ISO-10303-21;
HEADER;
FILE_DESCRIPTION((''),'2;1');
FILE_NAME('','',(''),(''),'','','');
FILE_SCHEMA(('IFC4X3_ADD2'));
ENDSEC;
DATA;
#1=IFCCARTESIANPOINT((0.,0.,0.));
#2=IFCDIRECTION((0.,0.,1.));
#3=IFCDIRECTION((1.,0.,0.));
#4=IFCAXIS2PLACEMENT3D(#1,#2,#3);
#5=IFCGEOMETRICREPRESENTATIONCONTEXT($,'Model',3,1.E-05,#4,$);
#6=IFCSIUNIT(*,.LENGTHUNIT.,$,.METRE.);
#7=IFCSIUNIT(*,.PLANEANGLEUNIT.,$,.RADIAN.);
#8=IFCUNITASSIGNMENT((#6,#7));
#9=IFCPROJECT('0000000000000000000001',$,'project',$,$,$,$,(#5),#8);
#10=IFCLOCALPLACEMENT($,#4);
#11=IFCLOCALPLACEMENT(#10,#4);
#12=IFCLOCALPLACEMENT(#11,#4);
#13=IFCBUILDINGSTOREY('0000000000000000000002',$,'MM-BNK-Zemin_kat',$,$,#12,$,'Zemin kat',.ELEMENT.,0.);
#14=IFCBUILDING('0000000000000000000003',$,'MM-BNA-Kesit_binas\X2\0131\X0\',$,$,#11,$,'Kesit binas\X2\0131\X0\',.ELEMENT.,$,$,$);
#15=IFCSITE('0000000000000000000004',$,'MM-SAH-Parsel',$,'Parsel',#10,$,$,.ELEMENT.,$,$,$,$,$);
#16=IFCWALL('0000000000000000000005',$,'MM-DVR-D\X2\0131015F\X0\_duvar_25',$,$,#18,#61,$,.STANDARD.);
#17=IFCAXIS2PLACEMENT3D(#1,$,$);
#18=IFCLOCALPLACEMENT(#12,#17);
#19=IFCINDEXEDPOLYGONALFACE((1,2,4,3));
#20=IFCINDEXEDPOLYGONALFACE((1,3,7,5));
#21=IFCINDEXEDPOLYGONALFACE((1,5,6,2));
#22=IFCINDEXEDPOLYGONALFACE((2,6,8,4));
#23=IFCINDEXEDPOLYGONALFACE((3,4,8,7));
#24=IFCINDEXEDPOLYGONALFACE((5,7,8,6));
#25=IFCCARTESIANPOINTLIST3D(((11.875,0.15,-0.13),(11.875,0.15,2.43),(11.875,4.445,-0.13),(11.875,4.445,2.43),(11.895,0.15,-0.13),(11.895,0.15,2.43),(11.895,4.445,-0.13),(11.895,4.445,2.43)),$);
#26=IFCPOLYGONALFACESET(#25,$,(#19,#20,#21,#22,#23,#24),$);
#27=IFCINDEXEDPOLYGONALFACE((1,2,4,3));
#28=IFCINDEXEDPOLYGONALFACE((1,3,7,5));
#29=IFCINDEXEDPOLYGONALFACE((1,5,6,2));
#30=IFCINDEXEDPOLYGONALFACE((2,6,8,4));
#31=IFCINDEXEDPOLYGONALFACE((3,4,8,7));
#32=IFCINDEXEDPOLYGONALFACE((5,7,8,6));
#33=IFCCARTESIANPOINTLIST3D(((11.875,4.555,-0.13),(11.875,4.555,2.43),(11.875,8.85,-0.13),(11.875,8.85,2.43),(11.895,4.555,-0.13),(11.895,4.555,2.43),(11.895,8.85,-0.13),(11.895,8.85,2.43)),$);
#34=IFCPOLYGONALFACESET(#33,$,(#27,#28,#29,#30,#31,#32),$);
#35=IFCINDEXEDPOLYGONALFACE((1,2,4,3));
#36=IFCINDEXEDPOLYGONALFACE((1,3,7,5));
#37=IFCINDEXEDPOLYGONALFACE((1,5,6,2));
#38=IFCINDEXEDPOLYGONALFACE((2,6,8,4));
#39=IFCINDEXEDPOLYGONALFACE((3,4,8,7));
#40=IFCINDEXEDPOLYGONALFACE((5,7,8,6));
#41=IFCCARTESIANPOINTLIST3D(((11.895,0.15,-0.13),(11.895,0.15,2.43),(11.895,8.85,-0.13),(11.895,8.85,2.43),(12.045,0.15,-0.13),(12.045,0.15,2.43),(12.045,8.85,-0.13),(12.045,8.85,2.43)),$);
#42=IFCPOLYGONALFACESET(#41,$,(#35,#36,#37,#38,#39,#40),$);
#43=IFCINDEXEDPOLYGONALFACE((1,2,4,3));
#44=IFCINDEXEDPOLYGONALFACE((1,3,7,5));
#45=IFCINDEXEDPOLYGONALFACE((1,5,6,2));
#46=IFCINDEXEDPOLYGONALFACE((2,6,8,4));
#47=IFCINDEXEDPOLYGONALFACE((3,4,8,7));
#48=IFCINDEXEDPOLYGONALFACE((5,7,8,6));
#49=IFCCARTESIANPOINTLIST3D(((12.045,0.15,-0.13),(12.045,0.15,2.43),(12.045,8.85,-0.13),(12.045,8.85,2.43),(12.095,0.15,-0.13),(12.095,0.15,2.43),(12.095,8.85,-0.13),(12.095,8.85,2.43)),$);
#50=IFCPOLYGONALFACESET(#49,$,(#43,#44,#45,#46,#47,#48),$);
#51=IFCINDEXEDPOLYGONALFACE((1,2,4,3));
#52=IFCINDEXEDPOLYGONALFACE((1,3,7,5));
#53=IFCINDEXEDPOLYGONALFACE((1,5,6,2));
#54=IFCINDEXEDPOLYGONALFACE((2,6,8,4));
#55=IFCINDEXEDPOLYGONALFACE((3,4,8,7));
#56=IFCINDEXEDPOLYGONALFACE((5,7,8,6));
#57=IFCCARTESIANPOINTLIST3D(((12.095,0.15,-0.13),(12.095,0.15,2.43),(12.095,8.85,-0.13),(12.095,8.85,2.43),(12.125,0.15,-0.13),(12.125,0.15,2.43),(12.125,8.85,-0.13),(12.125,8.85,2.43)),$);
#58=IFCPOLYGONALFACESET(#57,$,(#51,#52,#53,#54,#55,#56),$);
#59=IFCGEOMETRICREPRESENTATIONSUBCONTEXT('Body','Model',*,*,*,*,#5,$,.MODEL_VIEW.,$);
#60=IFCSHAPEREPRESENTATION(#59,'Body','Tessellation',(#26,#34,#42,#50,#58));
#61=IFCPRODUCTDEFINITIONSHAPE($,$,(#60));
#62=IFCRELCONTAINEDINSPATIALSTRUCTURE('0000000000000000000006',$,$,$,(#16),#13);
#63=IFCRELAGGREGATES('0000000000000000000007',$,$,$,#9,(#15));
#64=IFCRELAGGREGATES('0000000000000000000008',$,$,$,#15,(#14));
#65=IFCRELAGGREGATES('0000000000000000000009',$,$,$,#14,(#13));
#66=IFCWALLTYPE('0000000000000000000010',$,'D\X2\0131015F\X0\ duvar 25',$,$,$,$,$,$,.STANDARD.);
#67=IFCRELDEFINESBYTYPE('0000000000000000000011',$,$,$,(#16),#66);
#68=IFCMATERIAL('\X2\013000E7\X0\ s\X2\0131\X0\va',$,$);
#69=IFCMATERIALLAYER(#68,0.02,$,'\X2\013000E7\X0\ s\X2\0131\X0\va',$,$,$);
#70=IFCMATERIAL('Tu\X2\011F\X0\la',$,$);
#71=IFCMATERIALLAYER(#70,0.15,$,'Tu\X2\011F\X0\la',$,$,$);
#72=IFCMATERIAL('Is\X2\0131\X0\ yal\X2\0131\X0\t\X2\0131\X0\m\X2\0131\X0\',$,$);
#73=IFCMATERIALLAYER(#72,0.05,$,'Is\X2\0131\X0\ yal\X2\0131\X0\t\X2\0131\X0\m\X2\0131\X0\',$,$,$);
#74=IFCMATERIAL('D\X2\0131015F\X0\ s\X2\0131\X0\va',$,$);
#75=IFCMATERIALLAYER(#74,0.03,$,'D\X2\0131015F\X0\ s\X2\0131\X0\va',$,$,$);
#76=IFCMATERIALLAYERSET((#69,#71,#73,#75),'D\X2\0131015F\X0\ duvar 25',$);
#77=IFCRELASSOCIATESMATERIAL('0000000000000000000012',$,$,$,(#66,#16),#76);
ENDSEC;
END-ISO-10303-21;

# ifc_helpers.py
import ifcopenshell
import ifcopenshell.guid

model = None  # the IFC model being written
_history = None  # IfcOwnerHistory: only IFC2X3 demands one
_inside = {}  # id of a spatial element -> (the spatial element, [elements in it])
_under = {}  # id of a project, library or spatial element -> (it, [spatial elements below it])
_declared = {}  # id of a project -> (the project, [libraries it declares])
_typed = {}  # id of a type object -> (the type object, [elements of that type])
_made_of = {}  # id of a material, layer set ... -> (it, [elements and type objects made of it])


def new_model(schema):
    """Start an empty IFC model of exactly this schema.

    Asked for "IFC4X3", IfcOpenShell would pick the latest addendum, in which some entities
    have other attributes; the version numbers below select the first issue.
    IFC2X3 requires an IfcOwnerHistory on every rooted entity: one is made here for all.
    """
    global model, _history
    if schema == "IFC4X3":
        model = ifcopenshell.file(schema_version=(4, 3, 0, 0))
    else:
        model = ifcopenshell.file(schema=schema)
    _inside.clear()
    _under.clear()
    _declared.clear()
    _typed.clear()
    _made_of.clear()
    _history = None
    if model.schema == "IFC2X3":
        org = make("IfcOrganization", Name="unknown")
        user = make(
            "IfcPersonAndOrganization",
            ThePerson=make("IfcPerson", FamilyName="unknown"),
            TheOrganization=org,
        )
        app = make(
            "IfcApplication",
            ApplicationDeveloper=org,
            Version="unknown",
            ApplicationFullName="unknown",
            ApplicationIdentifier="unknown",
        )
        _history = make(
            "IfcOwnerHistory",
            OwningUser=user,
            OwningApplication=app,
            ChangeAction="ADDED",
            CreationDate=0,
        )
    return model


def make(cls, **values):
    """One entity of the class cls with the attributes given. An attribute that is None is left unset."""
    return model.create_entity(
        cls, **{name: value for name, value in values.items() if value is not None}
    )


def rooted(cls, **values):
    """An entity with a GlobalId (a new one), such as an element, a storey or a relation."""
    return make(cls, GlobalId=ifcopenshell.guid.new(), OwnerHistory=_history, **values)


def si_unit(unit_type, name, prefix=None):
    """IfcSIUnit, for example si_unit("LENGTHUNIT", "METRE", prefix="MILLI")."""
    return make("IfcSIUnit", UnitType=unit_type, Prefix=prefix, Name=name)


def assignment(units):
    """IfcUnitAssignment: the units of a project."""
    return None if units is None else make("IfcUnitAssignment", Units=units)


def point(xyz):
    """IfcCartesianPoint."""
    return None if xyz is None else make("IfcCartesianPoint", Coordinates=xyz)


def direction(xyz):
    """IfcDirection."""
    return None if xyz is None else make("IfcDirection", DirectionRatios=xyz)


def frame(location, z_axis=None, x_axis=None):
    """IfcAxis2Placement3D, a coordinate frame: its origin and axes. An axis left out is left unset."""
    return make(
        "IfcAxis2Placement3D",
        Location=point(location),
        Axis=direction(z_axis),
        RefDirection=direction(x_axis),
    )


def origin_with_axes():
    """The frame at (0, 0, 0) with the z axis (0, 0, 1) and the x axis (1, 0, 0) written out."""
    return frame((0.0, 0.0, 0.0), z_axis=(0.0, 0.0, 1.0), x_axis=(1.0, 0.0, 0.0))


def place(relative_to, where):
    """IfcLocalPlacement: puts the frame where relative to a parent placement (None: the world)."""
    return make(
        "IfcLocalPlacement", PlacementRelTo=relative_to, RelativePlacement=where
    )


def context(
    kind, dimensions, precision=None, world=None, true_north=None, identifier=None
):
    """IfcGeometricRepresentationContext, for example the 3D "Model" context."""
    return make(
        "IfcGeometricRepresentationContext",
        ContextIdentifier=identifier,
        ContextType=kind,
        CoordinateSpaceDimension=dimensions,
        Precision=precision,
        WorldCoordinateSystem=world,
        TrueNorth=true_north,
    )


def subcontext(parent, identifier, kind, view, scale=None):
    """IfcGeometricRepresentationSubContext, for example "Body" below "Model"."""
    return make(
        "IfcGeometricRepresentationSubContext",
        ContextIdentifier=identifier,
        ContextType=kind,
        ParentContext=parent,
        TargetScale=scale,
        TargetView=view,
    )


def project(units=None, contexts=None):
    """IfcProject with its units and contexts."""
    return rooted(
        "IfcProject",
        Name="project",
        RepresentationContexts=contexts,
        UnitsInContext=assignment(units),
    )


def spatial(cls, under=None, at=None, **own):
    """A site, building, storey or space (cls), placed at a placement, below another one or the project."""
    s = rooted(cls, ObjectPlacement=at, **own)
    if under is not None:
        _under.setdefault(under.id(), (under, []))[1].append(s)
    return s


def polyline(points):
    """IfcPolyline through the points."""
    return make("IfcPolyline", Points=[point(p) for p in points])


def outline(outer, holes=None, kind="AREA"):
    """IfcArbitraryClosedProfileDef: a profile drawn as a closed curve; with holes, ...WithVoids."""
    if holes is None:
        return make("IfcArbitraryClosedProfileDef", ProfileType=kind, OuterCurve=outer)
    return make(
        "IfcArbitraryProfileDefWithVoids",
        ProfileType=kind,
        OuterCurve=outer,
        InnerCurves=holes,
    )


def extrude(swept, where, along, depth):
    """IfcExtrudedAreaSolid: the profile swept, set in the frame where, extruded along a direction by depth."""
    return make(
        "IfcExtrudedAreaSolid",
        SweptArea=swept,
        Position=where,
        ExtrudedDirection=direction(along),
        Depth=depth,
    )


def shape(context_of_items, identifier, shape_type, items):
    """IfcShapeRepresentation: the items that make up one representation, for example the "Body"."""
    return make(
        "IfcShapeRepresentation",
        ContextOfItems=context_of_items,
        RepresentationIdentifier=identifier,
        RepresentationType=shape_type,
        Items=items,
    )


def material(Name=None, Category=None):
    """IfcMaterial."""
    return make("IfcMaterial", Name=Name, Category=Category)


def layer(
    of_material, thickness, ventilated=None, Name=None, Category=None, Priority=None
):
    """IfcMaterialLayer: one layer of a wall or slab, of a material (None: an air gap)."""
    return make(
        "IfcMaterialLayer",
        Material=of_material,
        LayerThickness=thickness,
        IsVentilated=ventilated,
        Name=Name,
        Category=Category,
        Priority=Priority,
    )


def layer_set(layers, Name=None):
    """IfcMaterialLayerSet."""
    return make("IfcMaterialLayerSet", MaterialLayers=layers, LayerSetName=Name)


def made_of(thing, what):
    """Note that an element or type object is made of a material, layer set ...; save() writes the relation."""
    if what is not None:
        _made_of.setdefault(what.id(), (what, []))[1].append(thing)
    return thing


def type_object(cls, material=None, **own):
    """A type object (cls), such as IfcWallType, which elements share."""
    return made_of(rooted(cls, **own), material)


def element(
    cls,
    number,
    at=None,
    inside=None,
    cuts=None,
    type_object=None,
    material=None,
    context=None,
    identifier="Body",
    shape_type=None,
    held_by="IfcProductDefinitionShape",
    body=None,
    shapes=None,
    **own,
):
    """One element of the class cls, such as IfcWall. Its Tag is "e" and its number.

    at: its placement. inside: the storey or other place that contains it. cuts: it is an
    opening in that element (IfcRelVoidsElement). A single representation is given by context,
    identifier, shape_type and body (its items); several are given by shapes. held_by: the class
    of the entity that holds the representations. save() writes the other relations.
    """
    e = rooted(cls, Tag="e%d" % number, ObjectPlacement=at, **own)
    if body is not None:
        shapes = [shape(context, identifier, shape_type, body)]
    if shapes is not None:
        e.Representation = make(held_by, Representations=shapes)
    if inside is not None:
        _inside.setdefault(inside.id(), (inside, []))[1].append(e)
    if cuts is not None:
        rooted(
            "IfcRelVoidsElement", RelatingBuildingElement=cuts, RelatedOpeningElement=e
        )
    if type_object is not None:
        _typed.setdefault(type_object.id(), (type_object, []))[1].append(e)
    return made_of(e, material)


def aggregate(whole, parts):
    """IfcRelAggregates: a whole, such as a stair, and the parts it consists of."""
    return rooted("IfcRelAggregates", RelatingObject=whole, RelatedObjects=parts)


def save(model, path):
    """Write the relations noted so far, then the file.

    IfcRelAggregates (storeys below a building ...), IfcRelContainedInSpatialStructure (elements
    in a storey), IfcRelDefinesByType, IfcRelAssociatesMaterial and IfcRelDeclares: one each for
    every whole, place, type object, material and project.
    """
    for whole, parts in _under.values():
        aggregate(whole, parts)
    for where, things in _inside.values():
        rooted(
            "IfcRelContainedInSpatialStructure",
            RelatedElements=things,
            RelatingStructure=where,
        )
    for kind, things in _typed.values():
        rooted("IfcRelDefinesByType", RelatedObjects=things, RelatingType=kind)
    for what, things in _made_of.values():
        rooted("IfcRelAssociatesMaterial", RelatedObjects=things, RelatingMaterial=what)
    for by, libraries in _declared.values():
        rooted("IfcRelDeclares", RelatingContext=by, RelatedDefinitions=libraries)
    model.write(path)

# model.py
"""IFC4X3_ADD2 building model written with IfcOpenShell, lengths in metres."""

from ifc_helpers import new_model, si_unit, frame, origin_with_axes, place, context, subcontext, project, spatial, polyline, outline, extrude, material, layer, layer_set, type_object, element, save


model = new_model("IFC4X3_ADD2")

# Units and contexts
model_context = context("Model", 3, precision=1e-05, world=origin_with_axes())
body_context = subcontext(model_context, "Body", "Model", "MODEL_VIEW")
ifc_project = project(units=[si_unit("LENGTHUNIT", "METRE"), si_unit("PLANEANGLEUNIT", "RADIAN")], contexts=[model_context])

# Site, building, storey
site_placement = place(None, origin_with_axes())
site = spatial("IfcSite", under=ifc_project, at=site_placement, Name="MM-SAH-Parsel", ObjectType="Parsel", CompositionType="ELEMENT")
building_placement = place(site_placement, origin_with_axes())
building = spatial("IfcBuilding", under=site, at=building_placement, Name="MM-BNA-Kesit_binası", LongName="Kesit binası", CompositionType="ELEMENT")
storey_placement = place(building_placement, origin_with_axes())
storey = spatial("IfcBuildingStorey", under=building, at=storey_placement, Name="MM-BNK-Zemin_kat", LongName="Zemin kat", CompositionType="ELEMENT", Elevation=0.0)

# Shared definitions
ifc_material_1 = material(Name="İç sıva")
ifc_layer_1 = layer(ifc_material_1, 0.02, Name="İç sıva")
ifc_material_2 = material(Name="Tuğla")
ifc_layer_2 = layer(ifc_material_2, 0.15, Name="Tuğla")
ifc_material_3 = material(Name="Isı yalıtımı")
ifc_layer_3 = layer(ifc_material_3, 0.05, Name="Isı yalıtımı")
ifc_material_4 = material(Name="Dış sıva")
ifc_layer_4 = layer(ifc_material_4, 0.03, Name="Dış sıva")
ifc_layer_set_1 = layer_set([ifc_layer_1, ifc_layer_2, ifc_layer_3, ifc_layer_4], Name="Dış duvar 25")
wall_type_1 = type_object("IfcWallType", Name="Dış duvar 25", PredefinedType="STANDARD", material=ifc_layer_set_1)

# Wall
wall_1_placement = place(storey_placement, origin_with_axes())
element("IfcWall", 1, at=wall_1_placement, inside=storey, type_object=wall_type_1, material=ifc_layer_set_1, Name="MM-DVR-Dış_duvar_25", PredefinedType="STANDARD", context=body_context, shape_type="SweptSolid", body=[
    extrude(outline(polyline([(11.895, 0.15), (11.895, 4.445), (11.875, 4.445), (11.875, 0.15), (11.895, 0.15)])), frame((0.0, 0.0, -0.13)), (0.0, 0.0, 1.0), 2.56),
    extrude(outline(polyline([(11.895, 4.555), (11.895, 8.85), (11.875, 8.85), (11.875, 4.555), (11.895, 4.555)])), frame((0.0, 0.0, -0.13)), (0.0, 0.0, 1.0), 2.56),
    extrude(outline(polyline([(12.045, 0.15), (12.045, 8.85), (11.895, 8.85), (11.895, 0.15), (12.045, 0.15)])), frame((0.0, 0.0, -0.13)), (0.0, 0.0, 1.0), 2.56),
    extrude(outline(polyline([(12.095, 0.15), (12.095, 8.85), (12.045, 8.85), (12.045, 0.15), (12.095, 0.15)])), frame((0.0, 0.0, -0.13)), (0.0, 0.0, 1.0), 2.56),
    extrude(outline(polyline([(12.125, 0.15), (12.125, 8.85), (12.095, 8.85), (12.095, 0.15), (12.125, 0.15)])), frame((0.0, 0.0, -0.13)), (0.0, 0.0, 1.0), 2.56),
])

save(model, "model.ifc")
